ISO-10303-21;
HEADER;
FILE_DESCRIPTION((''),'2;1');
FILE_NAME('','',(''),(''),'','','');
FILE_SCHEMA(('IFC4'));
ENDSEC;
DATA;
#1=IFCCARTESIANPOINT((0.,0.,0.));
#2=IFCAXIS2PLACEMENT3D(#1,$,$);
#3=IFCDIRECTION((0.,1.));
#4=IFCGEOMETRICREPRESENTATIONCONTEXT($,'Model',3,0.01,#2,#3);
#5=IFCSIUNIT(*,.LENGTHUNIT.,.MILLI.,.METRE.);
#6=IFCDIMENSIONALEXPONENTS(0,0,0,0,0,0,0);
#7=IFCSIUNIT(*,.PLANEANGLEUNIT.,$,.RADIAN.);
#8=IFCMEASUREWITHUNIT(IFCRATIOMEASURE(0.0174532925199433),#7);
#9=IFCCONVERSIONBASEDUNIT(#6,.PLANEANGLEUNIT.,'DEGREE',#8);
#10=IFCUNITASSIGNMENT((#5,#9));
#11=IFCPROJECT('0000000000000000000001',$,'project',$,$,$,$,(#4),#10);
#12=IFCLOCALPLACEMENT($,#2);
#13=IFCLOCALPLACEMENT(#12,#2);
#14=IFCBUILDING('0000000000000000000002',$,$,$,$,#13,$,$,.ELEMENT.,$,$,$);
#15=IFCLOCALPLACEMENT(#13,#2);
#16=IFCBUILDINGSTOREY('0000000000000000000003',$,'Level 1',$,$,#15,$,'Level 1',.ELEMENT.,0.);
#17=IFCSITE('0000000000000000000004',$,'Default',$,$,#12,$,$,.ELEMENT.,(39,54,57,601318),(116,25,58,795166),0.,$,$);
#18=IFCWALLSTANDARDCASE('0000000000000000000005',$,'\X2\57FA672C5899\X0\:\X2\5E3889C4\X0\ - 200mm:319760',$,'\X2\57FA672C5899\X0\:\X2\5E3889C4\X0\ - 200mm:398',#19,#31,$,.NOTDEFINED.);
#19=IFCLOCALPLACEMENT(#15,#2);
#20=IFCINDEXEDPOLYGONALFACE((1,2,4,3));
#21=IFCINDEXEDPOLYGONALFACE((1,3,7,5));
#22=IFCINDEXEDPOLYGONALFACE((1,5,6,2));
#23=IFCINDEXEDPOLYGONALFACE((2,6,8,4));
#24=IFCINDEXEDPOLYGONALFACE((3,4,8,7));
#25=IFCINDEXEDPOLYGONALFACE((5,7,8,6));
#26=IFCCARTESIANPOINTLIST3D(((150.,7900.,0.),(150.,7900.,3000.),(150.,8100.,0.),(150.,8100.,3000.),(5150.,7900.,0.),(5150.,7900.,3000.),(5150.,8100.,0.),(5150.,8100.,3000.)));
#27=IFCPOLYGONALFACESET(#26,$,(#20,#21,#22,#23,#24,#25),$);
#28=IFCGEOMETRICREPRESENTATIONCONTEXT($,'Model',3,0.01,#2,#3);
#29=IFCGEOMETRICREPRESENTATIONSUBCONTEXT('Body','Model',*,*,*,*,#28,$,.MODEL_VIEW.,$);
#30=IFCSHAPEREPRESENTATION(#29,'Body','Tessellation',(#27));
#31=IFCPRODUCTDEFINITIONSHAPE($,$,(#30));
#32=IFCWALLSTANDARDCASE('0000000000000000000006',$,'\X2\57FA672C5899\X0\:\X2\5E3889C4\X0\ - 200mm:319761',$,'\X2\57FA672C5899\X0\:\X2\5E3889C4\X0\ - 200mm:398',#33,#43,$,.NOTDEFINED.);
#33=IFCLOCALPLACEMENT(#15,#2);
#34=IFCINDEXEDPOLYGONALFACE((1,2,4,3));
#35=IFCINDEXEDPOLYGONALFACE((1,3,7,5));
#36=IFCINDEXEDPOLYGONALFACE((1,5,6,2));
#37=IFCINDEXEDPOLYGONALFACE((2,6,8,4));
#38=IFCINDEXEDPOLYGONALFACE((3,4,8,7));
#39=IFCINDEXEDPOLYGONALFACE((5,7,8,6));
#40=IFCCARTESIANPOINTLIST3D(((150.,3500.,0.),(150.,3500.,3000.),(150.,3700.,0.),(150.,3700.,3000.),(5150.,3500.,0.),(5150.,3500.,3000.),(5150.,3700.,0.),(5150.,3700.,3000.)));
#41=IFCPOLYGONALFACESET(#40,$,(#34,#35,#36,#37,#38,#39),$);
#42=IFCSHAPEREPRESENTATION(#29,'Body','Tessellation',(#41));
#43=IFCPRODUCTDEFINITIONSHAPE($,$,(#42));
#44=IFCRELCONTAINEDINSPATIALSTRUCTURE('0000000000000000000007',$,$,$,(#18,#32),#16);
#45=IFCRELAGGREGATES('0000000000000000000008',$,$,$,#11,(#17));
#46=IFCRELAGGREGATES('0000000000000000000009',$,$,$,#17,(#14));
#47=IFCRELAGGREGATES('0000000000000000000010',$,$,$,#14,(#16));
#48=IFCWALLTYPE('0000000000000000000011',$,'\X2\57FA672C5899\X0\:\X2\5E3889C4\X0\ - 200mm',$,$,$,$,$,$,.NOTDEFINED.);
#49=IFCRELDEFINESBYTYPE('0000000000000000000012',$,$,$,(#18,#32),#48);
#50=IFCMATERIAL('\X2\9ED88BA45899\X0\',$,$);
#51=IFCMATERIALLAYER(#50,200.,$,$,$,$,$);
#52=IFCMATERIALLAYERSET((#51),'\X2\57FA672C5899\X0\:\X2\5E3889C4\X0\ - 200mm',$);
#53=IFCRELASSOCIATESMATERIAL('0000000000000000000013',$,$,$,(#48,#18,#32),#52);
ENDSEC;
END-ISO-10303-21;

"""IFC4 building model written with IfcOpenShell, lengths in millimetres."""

from ifc_helpers import new_model, entity, si_unit, converted_unit, direction, frame, frame_2d, origin, place, context, subcontext, project, spatial, rectangle, extrude, material, layer, layer_set, layer_usage, type_object, element, save


model = new_model("IFC4")

# Units and contexts
model_context_1 = context("Model", 3, precision=0.01, world=origin(), true_north=direction((0.0, 1.0)))
model_context_2 = context("Model", 3, precision=0.01, world=origin(), true_north=direction((0.0, 1.0)))
body_context_1 = subcontext(model_context_2, "Body", "Model", "MODEL_VIEW")
ifc_project = project(units=[si_unit("LENGTHUNIT", "METRE", prefix="MILLI"), converted_unit("PLANEANGLEUNIT", "DEGREE", entity("IfcRatioMeasure", 0.0174532925199433), si_unit("PLANEANGLEUNIT", "RADIAN"), dimensions=[0, 0, 0, 0, 0, 0, 0])], contexts=[model_context_1])

# Site, building, storey
site_placement = place(None, origin())
site = spatial("IfcSite", under=ifc_project, at=site_placement, Name="Default", CompositionType="ELEMENT", RefLatitude=(39, 54, 57, 601318), RefLongitude=(116, 25, 58, 795166), RefElevation=0.0)
building_placement = place(site_placement, origin())
building = spatial("IfcBuilding", under=site, at=building_placement, CompositionType="ELEMENT")
storey_placement = place(building_placement, origin())
storey = spatial("IfcBuildingStorey", under=building, at=storey_placement, Name="Level 1", LongName="Level 1", CompositionType="ELEMENT", Elevation=0.0)

# Shared definitions
placement_1 = place(None, origin())
placement_2 = place(placement_1, origin())
placement_3 = place(placement_2, origin())

# Walls
ifc_material_1 = material(Name="默认墙")
ifc_layer_1 = layer(ifc_material_1, 200.0)
ifc_layer_set_1 = layer_set([ifc_layer_1], Name="基本墙:常规 - 200mm")
ifc_layer_usage_1 = layer_usage(ifc_layer_set_1, "AXIS2", "NEGATIVE", 100.0)
wall_type_1 = type_object("IfcWallType", Name="基本墙:常规 - 200mm", PredefinedType="NOTDEFINED", material=ifc_layer_set_1)
wall_1_placement = place(placement_3, frame((150.0, 8000.0, 0.0)))
element("IfcWallStandardCase", 1, at=wall_1_placement, inside=storey, type_object=wall_type_1, material=ifc_layer_usage_1, Name="基本墙:常规 - 200mm:319760", ObjectType="基本墙:常规 - 200mm:398", PredefinedType="NOTDEFINED", context=body_context_1, shape_type="SweptSolid", body=[
    extrude(rectangle(XDim=5000.0, YDim=200.0, at=frame_2d((2500.0, 0.0), x_axis=(-1.0, 0.0))), origin(), (0.0, 0.0, 1.0), 3000.0),
])
ifc_layer_usage_2 = layer_usage(ifc_layer_set_1, "AXIS2", "NEGATIVE", 100.0)
wall_2_placement = place(placement_3, frame((150.0, 3600.0, 0.0)))
element("IfcWallStandardCase", 2, at=wall_2_placement, inside=storey, type_object=wall_type_1, material=ifc_layer_usage_2, Name="基本墙:常规 - 200mm:319761", ObjectType="基本墙:常规 - 200mm:398", PredefinedType="NOTDEFINED", context=body_context_1, shape_type="SweptSolid", body=[
    extrude(rectangle(XDim=5000.0, YDim=200.0, at=frame_2d((2500.0, 0.0), x_axis=(-1.0, 0.0))), origin(), (0.0, 0.0, 1.0), 3000.0),
])

save(model, "model.ifc")
